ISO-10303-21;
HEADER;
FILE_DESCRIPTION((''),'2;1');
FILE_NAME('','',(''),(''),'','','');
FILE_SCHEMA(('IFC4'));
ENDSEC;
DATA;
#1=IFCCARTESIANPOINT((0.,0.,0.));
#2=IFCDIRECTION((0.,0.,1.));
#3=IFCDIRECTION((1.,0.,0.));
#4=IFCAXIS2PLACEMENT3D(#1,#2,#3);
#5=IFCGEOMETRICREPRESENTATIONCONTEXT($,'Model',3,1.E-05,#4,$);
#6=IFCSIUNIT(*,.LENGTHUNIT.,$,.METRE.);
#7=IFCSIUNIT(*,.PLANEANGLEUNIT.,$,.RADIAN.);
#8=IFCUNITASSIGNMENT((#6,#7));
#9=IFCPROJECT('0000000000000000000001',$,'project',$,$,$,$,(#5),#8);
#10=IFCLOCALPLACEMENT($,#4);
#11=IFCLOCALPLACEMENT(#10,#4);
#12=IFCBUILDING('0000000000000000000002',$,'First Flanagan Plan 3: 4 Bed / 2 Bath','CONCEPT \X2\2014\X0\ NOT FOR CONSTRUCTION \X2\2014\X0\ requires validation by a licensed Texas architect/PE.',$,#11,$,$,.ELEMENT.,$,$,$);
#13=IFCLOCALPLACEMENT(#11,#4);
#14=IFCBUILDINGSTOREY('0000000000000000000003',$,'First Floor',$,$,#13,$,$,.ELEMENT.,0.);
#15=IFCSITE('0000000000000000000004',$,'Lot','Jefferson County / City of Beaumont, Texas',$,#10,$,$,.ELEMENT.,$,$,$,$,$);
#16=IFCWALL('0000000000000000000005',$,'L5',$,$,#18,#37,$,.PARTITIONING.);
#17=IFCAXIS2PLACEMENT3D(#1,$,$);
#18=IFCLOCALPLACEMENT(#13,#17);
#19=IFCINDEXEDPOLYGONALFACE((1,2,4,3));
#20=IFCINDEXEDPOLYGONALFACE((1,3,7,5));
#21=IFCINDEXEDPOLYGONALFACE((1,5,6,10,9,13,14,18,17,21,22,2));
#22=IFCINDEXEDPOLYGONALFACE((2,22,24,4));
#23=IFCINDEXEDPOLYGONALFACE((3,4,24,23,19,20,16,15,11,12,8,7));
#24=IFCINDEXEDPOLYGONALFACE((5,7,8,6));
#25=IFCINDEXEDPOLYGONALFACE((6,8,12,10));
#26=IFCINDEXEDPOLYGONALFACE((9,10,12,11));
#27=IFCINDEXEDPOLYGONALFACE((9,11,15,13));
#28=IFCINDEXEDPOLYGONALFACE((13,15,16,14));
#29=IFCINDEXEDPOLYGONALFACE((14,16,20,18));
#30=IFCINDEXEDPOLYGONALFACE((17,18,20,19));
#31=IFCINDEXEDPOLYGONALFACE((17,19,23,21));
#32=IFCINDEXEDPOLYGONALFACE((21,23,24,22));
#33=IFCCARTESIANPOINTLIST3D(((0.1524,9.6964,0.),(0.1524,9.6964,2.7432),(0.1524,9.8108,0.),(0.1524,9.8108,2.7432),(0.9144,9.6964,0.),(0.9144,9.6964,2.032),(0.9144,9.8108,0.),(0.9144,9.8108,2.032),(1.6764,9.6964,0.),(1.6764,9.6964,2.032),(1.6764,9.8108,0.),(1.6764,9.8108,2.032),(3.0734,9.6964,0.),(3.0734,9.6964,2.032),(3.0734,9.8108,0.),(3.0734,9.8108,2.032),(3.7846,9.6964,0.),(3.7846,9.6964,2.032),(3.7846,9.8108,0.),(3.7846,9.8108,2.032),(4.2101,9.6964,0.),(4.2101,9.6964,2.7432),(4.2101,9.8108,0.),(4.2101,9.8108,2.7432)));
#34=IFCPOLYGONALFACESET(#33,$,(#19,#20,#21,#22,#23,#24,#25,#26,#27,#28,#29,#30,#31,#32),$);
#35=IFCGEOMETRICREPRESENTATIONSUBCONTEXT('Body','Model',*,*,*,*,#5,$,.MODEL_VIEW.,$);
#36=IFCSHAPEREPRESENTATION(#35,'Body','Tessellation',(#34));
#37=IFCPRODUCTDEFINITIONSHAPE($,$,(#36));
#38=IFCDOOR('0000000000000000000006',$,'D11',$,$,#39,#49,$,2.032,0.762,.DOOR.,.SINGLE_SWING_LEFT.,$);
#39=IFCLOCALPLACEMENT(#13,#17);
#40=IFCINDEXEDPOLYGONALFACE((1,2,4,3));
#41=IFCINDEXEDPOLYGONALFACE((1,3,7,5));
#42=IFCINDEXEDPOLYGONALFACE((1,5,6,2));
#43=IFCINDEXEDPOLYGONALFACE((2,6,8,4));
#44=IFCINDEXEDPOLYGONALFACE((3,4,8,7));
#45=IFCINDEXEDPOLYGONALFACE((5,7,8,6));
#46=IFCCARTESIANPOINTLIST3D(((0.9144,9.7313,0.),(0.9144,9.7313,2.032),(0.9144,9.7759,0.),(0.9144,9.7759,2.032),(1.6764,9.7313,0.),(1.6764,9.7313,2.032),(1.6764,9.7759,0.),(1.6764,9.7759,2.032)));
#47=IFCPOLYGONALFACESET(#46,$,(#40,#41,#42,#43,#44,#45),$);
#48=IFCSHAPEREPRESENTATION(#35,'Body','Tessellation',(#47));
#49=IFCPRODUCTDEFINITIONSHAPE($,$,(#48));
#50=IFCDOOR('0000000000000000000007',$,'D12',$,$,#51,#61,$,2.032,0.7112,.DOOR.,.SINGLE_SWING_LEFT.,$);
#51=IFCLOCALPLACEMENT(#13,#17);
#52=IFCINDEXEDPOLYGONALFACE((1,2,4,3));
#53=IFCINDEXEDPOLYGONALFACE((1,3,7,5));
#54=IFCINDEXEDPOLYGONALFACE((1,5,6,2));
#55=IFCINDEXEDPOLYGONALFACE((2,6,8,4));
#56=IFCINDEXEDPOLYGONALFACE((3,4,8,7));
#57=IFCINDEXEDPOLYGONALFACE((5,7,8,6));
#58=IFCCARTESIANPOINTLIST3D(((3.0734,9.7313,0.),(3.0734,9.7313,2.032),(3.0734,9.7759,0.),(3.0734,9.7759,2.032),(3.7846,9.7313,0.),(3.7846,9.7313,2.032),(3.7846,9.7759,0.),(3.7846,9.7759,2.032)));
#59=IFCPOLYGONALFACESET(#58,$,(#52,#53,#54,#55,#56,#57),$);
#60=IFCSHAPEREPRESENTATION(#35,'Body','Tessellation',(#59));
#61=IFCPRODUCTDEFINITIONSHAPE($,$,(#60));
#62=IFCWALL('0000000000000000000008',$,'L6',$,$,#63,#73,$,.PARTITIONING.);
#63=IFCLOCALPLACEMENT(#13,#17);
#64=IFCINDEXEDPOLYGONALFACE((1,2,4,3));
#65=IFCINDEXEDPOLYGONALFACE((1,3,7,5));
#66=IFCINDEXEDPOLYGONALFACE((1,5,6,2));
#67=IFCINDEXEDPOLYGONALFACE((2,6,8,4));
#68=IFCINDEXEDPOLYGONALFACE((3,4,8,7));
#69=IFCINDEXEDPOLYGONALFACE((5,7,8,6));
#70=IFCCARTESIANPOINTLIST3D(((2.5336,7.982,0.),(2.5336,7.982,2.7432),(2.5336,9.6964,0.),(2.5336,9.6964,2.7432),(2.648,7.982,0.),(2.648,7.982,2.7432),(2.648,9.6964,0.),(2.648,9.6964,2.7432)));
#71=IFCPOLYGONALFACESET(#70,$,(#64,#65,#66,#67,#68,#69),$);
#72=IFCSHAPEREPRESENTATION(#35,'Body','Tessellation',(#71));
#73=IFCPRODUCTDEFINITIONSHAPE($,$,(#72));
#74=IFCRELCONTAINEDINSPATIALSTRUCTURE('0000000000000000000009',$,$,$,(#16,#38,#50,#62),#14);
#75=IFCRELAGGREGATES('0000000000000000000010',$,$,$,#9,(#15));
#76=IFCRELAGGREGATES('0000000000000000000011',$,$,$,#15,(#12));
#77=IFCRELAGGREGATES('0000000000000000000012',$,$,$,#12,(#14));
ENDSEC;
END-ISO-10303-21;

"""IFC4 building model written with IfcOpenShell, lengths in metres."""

from ifc_helpers import new_model, si_unit, frame, frame_2d, origin_with_axes, place, context, subcontext, project, spatial, rectangle, extrude, element, fill, save


model = new_model("IFC4")

# Units and contexts
model_context = context("Model", 3, precision=1e-05, world=origin_with_axes())
body_context = subcontext(model_context, "Body", "Model", "MODEL_VIEW")
ifc_project = project(units=[si_unit("LENGTHUNIT", "METRE"), si_unit("PLANEANGLEUNIT", "RADIAN")], contexts=[model_context])

# Site, building, storey
site_placement = place(None, origin_with_axes())
site = spatial("IfcSite", under=ifc_project, at=site_placement, Name="Lot", Description="Jefferson County / City of Beaumont, Texas", CompositionType="ELEMENT")
building_placement = place(site_placement, origin_with_axes())
building = spatial("IfcBuilding", under=site, at=building_placement, Name="First Flanagan Plan 3: 4 Bed / 2 Bath", Description="CONCEPT — NOT FOR CONSTRUCTION — requires validation by a licensed Texas architect/PE.", CompositionType="ELEMENT")
storey_placement = place(building_placement, origin_with_axes())
storey = spatial("IfcBuildingStorey", under=building, at=storey_placement, Name="First Floor", CompositionType="ELEMENT", Elevation=0.0)

# Wall, openings, doors
wall_1_placement = place(storey_placement, frame((0.1524, 9.7536, 0.0), z_axis=(0.0, 0.0, 1.0), x_axis=(1.0, 0.0, 0.0)))
wall_1 = element("IfcWall", 1, at=wall_1_placement, inside=storey, Name="L5", PredefinedType="PARTITIONING", context=body_context, shape_type="SweptSolid", body=[
    extrude(rectangle(XDim=4.0577, YDim=0.1143, at=frame_2d((2.0288, 0.0), x_axis=(1.0, 0.0))), origin_with_axes(), (0.0, 0.0, 1.0), 2.7432),
])
opening_1_placement = place(wall_1_placement, frame((0.762, 0.0, 0.0), z_axis=(0.0, 0.0, 1.0), x_axis=(1.0, 0.0, 0.0)))
opening_1 = element("IfcOpeningElement", 2, at=opening_1_placement, cuts=wall_1, PredefinedType="OPENING", context=body_context, shape_type="SweptSolid", body=[
    extrude(rectangle(XDim=0.762, YDim=0.1448, at=frame_2d((0.381, 0.0), x_axis=(1.0, 0.0))), origin_with_axes(), (0.0, 0.0, 1.0), 2.032),
])
opening_2_placement = place(wall_1_placement, frame((2.921, 0.0, 0.0), z_axis=(0.0, 0.0, 1.0), x_axis=(1.0, 0.0, 0.0)))
opening_2 = element("IfcOpeningElement", 3, at=opening_2_placement, cuts=wall_1, PredefinedType="OPENING", context=body_context, shape_type="SweptSolid", body=[
    extrude(rectangle(XDim=0.7112, YDim=0.1448, at=frame_2d((0.3556, 0.0), x_axis=(1.0, 0.0))), origin_with_axes(), (0.0, 0.0, 1.0), 2.032),
])
door_1_placement = place(opening_1_placement, origin_with_axes())
door_1 = element("IfcDoor", 4, at=door_1_placement, inside=storey, Name="D11", OperationType="SINGLE_SWING_LEFT", OverallHeight=2.032, OverallWidth=0.762, PredefinedType="DOOR", context=body_context, shape_type="SweptSolid", body=[
    extrude(rectangle(XDim=0.762, YDim=0.0445, at=frame_2d((0.381, 0.0), x_axis=(1.0, 0.0))), origin_with_axes(), (0.0, 0.0, 1.0), 2.032),
])
fill(opening_1, door_1)
door_2_placement = place(opening_2_placement, origin_with_axes())
door_2 = element("IfcDoor", 5, at=door_2_placement, inside=storey, Name="D12", OperationType="SINGLE_SWING_LEFT", OverallHeight=2.032, OverallWidth=0.7112, PredefinedType="DOOR", context=body_context, shape_type="SweptSolid", body=[
    extrude(rectangle(XDim=0.7112, YDim=0.0445, at=frame_2d((0.3556, 0.0), x_axis=(1.0, 0.0))), origin_with_axes(), (0.0, 0.0, 1.0), 2.032),
])
fill(opening_2, door_2)

# Wall
wall_2_placement = place(storey_placement, frame((2.5908, 7.982, 0.0), z_axis=(0.0, 0.0, 1.0), x_axis=(0.0, 1.0, 0.0)))
element("IfcWall", 6, at=wall_2_placement, inside=storey, Name="L6", PredefinedType="PARTITIONING", context=body_context, shape_type="SweptSolid", body=[
    extrude(rectangle(XDim=1.7145, YDim=0.1143, at=frame_2d((0.8573, 0.0), x_axis=(1.0, 0.0))), origin_with_axes(), (0.0, 0.0, 1.0), 2.7432),
])

save(model, "model.ifc")
